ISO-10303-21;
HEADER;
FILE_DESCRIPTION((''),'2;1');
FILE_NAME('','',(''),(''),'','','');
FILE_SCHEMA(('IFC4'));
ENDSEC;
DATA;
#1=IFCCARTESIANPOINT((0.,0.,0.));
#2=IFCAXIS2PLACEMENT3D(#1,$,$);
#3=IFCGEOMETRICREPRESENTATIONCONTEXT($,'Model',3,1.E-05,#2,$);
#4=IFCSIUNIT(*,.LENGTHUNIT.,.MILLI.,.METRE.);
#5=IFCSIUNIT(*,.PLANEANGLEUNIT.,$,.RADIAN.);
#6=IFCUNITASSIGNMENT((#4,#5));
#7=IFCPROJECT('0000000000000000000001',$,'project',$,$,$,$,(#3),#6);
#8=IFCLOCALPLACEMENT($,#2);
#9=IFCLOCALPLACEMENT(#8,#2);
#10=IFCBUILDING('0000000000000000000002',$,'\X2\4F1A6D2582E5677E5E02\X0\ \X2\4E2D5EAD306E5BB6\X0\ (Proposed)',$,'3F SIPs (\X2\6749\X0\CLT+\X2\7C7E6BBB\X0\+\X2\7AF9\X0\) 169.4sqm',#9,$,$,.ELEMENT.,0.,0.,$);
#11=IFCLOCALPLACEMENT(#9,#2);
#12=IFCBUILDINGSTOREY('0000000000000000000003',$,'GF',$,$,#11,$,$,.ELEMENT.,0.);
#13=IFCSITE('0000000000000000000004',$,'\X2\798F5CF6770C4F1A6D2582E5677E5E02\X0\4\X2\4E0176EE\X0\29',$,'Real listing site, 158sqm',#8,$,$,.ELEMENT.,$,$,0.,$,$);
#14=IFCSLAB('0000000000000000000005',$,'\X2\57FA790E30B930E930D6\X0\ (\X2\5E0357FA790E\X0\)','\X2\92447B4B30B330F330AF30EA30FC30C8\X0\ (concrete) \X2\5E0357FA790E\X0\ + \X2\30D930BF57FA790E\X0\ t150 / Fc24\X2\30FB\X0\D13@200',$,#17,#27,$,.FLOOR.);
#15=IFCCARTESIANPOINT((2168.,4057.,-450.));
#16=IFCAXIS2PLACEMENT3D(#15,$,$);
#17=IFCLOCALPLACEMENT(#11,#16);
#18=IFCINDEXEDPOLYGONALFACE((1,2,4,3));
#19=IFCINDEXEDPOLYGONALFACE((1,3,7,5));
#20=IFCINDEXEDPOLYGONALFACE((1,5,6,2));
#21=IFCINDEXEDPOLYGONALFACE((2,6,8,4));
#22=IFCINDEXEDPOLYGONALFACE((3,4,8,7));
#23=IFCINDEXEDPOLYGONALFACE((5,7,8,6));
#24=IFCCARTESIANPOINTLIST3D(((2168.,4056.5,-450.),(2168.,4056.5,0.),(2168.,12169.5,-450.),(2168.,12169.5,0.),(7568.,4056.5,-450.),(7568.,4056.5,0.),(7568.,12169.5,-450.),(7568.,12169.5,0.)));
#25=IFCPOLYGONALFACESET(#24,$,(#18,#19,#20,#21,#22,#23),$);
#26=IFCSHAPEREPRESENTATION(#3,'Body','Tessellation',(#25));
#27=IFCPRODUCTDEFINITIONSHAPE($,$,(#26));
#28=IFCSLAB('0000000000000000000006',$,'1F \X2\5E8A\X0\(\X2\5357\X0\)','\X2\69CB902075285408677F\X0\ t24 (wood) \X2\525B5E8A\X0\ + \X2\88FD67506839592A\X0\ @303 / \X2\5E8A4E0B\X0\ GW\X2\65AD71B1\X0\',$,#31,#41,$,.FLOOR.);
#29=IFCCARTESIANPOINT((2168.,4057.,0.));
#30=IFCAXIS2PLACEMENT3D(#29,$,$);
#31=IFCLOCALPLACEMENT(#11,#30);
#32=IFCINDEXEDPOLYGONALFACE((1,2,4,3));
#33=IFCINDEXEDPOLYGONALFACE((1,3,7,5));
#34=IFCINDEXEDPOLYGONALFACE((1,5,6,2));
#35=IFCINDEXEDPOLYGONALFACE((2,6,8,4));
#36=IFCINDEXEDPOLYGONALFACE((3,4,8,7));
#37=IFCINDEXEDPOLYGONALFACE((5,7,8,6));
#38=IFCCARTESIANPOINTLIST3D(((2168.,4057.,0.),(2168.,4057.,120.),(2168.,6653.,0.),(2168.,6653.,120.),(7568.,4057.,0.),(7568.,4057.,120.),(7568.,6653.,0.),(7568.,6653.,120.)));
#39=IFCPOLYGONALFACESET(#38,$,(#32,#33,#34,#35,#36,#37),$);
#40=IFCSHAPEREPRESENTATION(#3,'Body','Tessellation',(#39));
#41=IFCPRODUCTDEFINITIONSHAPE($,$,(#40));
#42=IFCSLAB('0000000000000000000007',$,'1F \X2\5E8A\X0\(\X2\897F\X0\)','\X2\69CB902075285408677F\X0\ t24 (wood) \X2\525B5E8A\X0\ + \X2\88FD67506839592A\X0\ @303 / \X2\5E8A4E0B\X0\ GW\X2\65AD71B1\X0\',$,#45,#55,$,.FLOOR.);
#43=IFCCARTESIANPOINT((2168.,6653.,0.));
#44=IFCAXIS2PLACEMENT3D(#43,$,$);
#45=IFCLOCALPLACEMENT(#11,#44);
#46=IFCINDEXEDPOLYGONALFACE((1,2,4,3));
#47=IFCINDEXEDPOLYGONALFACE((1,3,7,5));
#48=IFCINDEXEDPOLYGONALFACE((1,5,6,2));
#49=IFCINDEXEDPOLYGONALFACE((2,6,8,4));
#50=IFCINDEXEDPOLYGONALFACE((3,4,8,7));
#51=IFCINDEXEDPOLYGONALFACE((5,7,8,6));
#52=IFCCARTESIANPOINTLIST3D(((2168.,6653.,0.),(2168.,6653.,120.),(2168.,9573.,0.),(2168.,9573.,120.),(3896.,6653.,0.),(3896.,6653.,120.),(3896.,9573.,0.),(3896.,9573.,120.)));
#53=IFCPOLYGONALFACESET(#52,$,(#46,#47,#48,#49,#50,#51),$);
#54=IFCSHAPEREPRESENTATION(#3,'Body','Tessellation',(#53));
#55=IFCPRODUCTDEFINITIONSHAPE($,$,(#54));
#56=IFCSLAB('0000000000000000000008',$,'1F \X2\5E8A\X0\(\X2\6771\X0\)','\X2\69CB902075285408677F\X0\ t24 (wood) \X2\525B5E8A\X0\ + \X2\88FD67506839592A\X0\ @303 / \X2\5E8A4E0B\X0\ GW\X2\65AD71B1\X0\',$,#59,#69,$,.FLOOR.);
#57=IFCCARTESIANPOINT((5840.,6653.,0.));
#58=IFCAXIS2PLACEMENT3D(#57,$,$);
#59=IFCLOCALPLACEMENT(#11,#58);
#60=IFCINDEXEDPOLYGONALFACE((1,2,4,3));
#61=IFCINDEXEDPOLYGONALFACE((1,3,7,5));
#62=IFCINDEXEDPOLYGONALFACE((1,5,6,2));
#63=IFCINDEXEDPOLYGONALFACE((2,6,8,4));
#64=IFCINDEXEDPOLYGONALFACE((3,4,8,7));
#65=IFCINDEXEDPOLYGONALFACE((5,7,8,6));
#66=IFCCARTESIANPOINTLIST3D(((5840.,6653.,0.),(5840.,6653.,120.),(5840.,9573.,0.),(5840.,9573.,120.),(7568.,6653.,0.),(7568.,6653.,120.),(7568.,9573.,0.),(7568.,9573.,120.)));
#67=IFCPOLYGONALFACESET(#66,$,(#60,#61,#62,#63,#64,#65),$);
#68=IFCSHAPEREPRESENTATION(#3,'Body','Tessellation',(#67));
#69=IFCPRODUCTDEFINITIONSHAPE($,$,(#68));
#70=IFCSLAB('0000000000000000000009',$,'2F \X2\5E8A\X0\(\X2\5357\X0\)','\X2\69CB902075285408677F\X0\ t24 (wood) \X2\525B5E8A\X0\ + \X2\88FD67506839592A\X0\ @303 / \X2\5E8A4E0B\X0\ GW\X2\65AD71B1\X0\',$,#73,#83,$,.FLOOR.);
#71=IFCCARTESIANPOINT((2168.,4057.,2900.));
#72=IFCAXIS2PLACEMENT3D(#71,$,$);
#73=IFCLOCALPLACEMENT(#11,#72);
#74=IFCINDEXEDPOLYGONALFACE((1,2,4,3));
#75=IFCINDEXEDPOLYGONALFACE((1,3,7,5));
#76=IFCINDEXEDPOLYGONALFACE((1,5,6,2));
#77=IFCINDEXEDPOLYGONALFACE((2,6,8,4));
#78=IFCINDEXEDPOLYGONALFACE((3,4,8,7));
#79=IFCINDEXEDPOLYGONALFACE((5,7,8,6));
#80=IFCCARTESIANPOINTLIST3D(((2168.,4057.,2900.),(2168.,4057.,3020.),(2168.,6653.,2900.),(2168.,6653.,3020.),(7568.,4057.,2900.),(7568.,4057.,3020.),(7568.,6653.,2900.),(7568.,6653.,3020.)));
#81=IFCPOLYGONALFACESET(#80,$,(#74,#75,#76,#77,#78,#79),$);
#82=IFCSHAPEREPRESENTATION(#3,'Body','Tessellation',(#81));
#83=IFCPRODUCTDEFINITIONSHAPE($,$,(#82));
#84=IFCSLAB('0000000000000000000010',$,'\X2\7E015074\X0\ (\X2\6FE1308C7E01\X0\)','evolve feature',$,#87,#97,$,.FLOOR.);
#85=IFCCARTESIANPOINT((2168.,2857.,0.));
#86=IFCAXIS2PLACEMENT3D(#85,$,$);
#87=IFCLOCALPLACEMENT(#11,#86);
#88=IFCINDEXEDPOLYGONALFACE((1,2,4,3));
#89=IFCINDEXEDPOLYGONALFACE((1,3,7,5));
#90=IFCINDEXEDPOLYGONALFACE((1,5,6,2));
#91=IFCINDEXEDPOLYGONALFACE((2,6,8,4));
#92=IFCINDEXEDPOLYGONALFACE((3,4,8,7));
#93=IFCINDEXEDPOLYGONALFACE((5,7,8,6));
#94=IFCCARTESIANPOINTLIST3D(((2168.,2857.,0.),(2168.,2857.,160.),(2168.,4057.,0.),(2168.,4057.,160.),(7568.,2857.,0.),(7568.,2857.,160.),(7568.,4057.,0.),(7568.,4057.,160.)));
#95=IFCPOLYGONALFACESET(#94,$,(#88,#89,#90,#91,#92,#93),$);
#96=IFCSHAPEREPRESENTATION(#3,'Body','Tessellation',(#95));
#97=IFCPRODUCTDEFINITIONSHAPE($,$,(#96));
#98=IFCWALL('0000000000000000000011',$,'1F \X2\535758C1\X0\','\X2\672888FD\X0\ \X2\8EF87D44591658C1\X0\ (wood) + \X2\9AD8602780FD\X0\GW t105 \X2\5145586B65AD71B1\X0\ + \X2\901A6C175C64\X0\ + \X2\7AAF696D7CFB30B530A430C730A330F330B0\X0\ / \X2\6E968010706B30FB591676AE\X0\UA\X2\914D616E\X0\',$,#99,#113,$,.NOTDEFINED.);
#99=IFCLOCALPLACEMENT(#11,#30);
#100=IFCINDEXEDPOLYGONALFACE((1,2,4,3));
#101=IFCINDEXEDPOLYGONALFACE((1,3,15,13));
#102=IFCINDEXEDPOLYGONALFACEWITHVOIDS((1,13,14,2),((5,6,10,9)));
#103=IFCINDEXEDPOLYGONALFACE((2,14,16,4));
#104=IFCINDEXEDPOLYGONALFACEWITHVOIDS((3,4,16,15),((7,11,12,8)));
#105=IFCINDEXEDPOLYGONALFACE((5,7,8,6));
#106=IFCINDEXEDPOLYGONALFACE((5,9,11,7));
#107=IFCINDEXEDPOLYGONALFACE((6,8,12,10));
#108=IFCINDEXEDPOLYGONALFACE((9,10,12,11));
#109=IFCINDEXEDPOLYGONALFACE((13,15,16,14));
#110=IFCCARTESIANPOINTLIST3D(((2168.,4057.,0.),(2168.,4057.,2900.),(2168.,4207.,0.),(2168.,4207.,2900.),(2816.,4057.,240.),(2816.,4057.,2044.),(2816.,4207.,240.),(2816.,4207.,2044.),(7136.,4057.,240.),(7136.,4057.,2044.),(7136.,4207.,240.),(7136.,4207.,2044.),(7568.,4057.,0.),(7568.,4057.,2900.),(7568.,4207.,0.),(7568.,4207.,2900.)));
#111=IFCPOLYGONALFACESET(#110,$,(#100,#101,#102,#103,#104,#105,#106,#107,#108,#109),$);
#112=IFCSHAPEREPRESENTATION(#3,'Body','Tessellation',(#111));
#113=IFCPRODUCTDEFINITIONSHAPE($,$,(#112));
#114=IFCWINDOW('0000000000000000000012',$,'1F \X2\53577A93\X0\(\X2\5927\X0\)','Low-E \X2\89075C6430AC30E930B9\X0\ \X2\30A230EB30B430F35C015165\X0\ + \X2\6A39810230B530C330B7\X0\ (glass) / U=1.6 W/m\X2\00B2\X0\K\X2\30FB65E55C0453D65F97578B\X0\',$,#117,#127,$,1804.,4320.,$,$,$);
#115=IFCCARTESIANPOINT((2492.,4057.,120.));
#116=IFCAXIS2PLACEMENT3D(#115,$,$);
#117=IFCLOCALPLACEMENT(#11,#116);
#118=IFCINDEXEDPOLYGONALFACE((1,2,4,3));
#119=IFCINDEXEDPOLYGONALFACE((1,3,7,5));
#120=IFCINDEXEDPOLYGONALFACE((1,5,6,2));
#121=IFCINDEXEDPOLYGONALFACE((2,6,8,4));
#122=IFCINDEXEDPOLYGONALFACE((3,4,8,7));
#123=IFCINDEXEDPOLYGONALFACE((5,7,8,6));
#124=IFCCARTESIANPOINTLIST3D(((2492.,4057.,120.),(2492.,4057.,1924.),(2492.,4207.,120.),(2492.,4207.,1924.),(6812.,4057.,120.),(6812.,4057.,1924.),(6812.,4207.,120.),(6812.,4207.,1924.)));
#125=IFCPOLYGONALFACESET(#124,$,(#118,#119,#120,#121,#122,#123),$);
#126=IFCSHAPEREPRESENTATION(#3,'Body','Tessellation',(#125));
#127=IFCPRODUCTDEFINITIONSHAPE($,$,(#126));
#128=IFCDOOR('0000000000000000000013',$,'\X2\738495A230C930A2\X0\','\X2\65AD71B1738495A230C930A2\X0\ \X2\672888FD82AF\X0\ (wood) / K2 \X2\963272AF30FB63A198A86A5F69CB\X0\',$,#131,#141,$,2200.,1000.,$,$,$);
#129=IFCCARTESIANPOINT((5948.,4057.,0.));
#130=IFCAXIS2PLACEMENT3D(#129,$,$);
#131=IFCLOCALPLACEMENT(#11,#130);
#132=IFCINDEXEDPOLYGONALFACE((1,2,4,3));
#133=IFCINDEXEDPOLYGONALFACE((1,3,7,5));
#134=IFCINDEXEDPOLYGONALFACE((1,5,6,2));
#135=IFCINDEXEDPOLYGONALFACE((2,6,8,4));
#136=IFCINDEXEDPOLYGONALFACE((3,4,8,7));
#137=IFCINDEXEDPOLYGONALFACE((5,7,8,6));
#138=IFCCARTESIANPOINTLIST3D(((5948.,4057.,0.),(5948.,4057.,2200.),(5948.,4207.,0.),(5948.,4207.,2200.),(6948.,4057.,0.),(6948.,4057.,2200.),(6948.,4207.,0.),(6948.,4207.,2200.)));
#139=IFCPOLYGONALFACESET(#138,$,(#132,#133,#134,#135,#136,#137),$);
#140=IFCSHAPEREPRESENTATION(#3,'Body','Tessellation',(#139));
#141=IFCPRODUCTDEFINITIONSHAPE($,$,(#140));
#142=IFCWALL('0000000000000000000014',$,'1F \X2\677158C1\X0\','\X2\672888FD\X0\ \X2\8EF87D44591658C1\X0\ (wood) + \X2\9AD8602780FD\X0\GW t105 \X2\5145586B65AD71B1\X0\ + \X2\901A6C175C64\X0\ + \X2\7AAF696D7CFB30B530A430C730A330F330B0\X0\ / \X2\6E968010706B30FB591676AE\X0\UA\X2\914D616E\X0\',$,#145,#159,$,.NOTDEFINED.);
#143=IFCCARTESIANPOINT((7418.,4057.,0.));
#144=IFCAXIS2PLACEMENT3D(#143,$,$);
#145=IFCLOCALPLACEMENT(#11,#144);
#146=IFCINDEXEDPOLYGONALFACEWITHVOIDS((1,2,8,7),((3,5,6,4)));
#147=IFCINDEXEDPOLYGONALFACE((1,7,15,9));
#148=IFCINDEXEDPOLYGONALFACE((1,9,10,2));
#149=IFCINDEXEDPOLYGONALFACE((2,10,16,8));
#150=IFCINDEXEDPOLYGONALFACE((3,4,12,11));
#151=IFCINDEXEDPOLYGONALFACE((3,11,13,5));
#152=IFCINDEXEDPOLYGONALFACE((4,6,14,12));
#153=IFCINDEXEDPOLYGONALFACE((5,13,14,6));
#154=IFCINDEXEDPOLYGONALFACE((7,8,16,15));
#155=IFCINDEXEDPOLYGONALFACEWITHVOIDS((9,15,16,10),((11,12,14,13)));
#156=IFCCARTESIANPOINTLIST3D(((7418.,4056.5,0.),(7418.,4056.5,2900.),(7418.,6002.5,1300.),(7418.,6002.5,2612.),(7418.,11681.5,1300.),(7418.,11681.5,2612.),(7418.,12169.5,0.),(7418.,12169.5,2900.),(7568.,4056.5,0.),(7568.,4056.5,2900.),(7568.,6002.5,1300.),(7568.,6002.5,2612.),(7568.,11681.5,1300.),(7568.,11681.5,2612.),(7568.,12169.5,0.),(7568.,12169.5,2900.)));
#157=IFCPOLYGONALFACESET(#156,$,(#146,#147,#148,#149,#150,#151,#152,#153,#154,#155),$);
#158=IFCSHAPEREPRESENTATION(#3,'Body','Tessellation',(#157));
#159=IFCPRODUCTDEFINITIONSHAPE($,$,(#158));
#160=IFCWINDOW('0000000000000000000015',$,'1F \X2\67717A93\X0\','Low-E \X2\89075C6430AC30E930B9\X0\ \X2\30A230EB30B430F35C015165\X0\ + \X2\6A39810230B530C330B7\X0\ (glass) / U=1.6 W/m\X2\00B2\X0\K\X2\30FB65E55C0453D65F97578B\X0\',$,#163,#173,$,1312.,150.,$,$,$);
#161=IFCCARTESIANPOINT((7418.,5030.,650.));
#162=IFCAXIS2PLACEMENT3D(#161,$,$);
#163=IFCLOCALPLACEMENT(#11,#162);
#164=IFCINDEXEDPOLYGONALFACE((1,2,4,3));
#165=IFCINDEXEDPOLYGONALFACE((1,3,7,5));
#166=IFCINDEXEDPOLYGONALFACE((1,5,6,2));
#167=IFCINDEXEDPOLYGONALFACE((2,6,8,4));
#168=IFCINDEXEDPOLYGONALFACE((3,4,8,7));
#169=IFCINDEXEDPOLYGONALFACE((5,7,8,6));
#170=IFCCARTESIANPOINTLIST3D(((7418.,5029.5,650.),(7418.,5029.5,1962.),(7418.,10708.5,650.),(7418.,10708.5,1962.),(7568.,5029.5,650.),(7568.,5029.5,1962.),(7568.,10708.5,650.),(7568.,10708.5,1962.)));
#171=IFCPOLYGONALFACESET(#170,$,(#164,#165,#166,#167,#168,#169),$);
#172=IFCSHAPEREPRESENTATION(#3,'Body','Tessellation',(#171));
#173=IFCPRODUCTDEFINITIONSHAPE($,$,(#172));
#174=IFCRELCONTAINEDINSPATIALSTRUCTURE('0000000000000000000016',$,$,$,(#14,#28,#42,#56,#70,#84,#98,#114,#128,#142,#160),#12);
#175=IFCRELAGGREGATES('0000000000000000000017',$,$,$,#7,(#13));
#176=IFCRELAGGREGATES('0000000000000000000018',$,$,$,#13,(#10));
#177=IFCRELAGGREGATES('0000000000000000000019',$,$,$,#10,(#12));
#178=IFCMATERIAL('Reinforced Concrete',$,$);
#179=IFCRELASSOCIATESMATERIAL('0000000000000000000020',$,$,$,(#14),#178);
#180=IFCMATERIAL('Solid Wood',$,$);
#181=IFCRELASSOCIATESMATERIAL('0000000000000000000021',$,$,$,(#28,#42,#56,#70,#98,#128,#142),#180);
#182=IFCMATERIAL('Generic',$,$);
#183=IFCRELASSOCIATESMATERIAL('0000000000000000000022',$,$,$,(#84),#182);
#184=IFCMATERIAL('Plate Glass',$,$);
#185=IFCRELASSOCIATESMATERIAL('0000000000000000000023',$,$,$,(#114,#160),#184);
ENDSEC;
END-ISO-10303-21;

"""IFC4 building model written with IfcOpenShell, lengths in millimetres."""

from ifc_helpers import new_model, si_unit, frame, frame_2d, origin, place, context, project, spatial, rectangle, extrude, material, element, fill, save


model = new_model("IFC4")

# Units and contexts
model_context = context("Model", 3, precision=1e-05, world=origin())
ifc_project = project(units=[si_unit("LENGTHUNIT", "METRE", prefix="MILLI"), si_unit("PLANEANGLEUNIT", "RADIAN")], contexts=[model_context])

# Site, building, storey
site_placement = place(None, origin())
site = spatial("IfcSite", under=ifc_project, at=site_placement, Name="福島県会津若松市4丁目29", ObjectType="Real listing site, 158sqm", CompositionType="ELEMENT", RefElevation=0.0)
building_placement = place(site_placement, origin())
building = spatial("IfcBuilding", under=site, at=building_placement, Name="会津若松市 中庭の家 (Proposed)", ObjectType="3F SIPs (杉CLT+籾殻+竹) 169.4sqm", CompositionType="ELEMENT", ElevationOfRefHeight=0.0, ElevationOfTerrain=0.0)
storey_placement = place(building_placement, origin())
storey = spatial("IfcBuildingStorey", under=building, at=storey_placement, Name="GF", CompositionType="ELEMENT", Elevation=0.0)

# Slabs
ifc_material_1 = material(Name="Reinforced Concrete")
slab_1_placement = place(storey_placement, frame((2168.0, 4057.0, -450.0)))
element("IfcSlab", 1, at=slab_1_placement, inside=storey, material=ifc_material_1, Name="基礎スラブ (布基礎)", Description="鉄筋コンクリート (concrete) 布基礎 + ベタ基礎 t150 / Fc24・D13@200", PredefinedType="FLOOR", context=model_context, shape_type="SweptSolid", body=[
    extrude(rectangle(XDim=5400.0, YDim=8113.0, at=frame_2d((2700.0, 4056.0))), frame((2168.0, 4057.0, -450.0)), (0.0, 0.0, 1.0), 450.0),
])
ifc_material_2 = material(Name="Solid Wood")
slab_2_placement = place(storey_placement, frame((2168.0, 4057.0, 0.0)))
element("IfcSlab", 2, at=slab_2_placement, inside=storey, material=ifc_material_2, Name="1F 床(南)", Description="構造用合板 t24 (wood) 剛床 + 製材根太 @303 / 床下 GW断熱", PredefinedType="FLOOR", context=model_context, shape_type="SweptSolid", body=[
    extrude(rectangle(XDim=5400.0, YDim=2596.0, at=frame_2d((2700.0, 1298.0))), frame((2168.0, 4057.0, 0.0)), (0.0, 0.0, 1.0), 120.0),
])
slab_3_placement = place(storey_placement, frame((2168.0, 6653.0, 0.0)))
element("IfcSlab", 3, at=slab_3_placement, inside=storey, material=ifc_material_2, Name="1F 床(西)", Description="構造用合板 t24 (wood) 剛床 + 製材根太 @303 / 床下 GW断熱", PredefinedType="FLOOR", context=model_context, shape_type="SweptSolid", body=[
    extrude(rectangle(XDim=1728.0, YDim=2920.0, at=frame_2d((864.0, 1460.0))), frame((2168.0, 6653.0, 0.0)), (0.0, 0.0, 1.0), 120.0),
])
slab_4_placement = place(storey_placement, frame((5840.0, 6653.0, 0.0)))
element("IfcSlab", 4, at=slab_4_placement, inside=storey, material=ifc_material_2, Name="1F 床(東)", Description="構造用合板 t24 (wood) 剛床 + 製材根太 @303 / 床下 GW断熱", PredefinedType="FLOOR", context=model_context, shape_type="SweptSolid", body=[
    extrude(rectangle(XDim=1728.0, YDim=2920.0, at=frame_2d((864.0, 1460.0))), frame((5840.0, 6653.0, 0.0)), (0.0, 0.0, 1.0), 120.0),
])
slab_5_placement = place(storey_placement, frame((2168.0, 4057.0, 2900.0)))
element("IfcSlab", 5, at=slab_5_placement, inside=storey, material=ifc_material_2, Name="2F 床(南)", Description="構造用合板 t24 (wood) 剛床 + 製材根太 @303 / 床下 GW断熱", PredefinedType="FLOOR", context=model_context, shape_type="SweptSolid", body=[
    extrude(rectangle(XDim=5400.0, YDim=2596.0, at=frame_2d((2700.0, 1298.0))), frame((2168.0, 4057.0, 2900.0)), (0.0, 0.0, 1.0), 120.0),
])
ifc_material_3 = material(Name="Generic")
slab_6_placement = place(storey_placement, frame((2168.0, 2857.0, 0.0)))
element("IfcSlab", 6, at=slab_6_placement, inside=storey, material=ifc_material_3, Name="縁側 (濡れ縁)", Description="evolve feature", PredefinedType="FLOOR", context=model_context, shape_type="SweptSolid", body=[
    extrude(rectangle(XDim=5400.0, YDim=1200.0, at=frame_2d((2700.0, 600.0))), frame((2168.0, 2857.0, 0.0)), (0.0, 0.0, 1.0), 160.0),
])

# Wall, openings, window, door
wall_1_placement = place(storey_placement, frame((2168.0, 4057.0, 0.0)))
wall_1 = element("IfcWall", 7, at=wall_1_placement, inside=storey, material=ifc_material_2, Name="1F 南壁", Description="木製 軸組外壁 (wood) + 高性能GW t105 充填断熱 + 通気層 + 窯業系サイディング / 準耐火・外皮UA配慮", PredefinedType="NOTDEFINED", context=model_context, shape_type="SweptSolid", body=[
    extrude(rectangle(XDim=5400.0, YDim=150.0, at=frame_2d((2700.0, 75.0))), frame((2168.0, 4057.0, 0.0)), (0.0, 0.0, 1.0), 2900.0),
])
opening_1_placement = place(storey_placement, frame((2492.0, 4057.0, 120.0)))
opening_1 = element("IfcOpeningElement", 8, at=opening_1_placement, cuts=wall_1, PredefinedType="NOTDEFINED", context=model_context, shape_type="SweptSolid", body=[
    extrude(rectangle(XDim=4320.0, YDim=150.0, at=frame_2d((2160.0, 75.0))), frame((2492.0, 4057.0, 120.0)), (0.0, 0.0, 1.0), 1804.0),
])
opening_2_placement = place(storey_placement, frame((5948.0, 4057.0, 0.0)))
opening_2 = element("IfcOpeningElement", 9, at=opening_2_placement, cuts=wall_1, PredefinedType="NOTDEFINED", context=model_context, shape_type="SweptSolid", body=[
    extrude(rectangle(XDim=1000.0, YDim=150.0, at=frame_2d((500.0, 75.0))), frame((5948.0, 4057.0, 0.0)), (0.0, 0.0, 1.0), 2200.0),
])
ifc_material_4 = material(Name="Plate Glass")
window_1_placement = place(storey_placement, frame((2492.0, 4057.0, 120.0)))
window_1 = element("IfcWindow", 10, at=window_1_placement, inside=storey, material=ifc_material_4, Name="1F 南窓(大)", Description="Low-E 複層ガラス アルゴン封入 + 樹脂サッシ (glass) / U=1.6 W/m²K・日射取得型", OverallHeight=1804.0, OverallWidth=4320.0, context=model_context, shape_type="SweptSolid", body=[
    extrude(rectangle(XDim=4320.0, YDim=150.0, at=frame_2d((2160.0, 75.0))), frame((2492.0, 4057.0, 120.0)), (0.0, 0.0, 1.0), 1804.0),
])
fill(opening_1, window_1)
door_placement = place(storey_placement, frame((5948.0, 4057.0, 0.0)))
door = element("IfcDoor", 11, at=door_placement, inside=storey, material=ifc_material_2, Name="玄関ドア", Description="断熱玄関ドア 木製芯 (wood) / K2 防犯・採風機構", OverallHeight=2200.0, OverallWidth=1000.0, context=model_context, shape_type="SweptSolid", body=[
    extrude(rectangle(XDim=1000.0, YDim=150.0, at=frame_2d((500.0, 75.0))), frame((5948.0, 4057.0, 0.0)), (0.0, 0.0, 1.0), 2200.0),
])
fill(opening_2, door)

# Wall, opening, window
wall_2_placement = place(storey_placement, frame((7418.0, 4057.0, 0.0)))
wall_2 = element("IfcWall", 12, at=wall_2_placement, inside=storey, material=ifc_material_2, Name="1F 東壁", Description="木製 軸組外壁 (wood) + 高性能GW t105 充填断熱 + 通気層 + 窯業系サイディング / 準耐火・外皮UA配慮", PredefinedType="NOTDEFINED", context=model_context, shape_type="SweptSolid", body=[
    extrude(rectangle(XDim=150.0, YDim=8113.0, at=frame_2d((75.0, 4056.0))), frame((7418.0, 4057.0, 0.0)), (0.0, 0.0, 1.0), 2900.0),
])
opening_3_placement = place(storey_placement, frame((7418.0, 5030.0, 650.0)))
opening_3 = element("IfcOpeningElement", 13, at=opening_3_placement, cuts=wall_2, PredefinedType="NOTDEFINED", context=model_context, shape_type="SweptSolid", body=[
    extrude(rectangle(XDim=150.0, YDim=5679.0, at=frame_2d((75.0, 2839.0))), frame((7418.0, 5030.0, 650.0)), (0.0, 0.0, 1.0), 1312.0),
])
window_2_placement = place(storey_placement, frame((7418.0, 5030.0, 650.0)))
window_2 = element("IfcWindow", 14, at=window_2_placement, inside=storey, material=ifc_material_4, Name="1F 東窓", Description="Low-E 複層ガラス アルゴン封入 + 樹脂サッシ (glass) / U=1.6 W/m²K・日射取得型", OverallHeight=1312.0, OverallWidth=150.0, context=model_context, shape_type="SweptSolid", body=[
    extrude(rectangle(XDim=150.0, YDim=5679.0, at=frame_2d((75.0, 2839.0))), frame((7418.0, 5030.0, 650.0)), (0.0, 0.0, 1.0), 1312.0),
])
fill(opening_3, window_2)

save(model, "model.ifc")
